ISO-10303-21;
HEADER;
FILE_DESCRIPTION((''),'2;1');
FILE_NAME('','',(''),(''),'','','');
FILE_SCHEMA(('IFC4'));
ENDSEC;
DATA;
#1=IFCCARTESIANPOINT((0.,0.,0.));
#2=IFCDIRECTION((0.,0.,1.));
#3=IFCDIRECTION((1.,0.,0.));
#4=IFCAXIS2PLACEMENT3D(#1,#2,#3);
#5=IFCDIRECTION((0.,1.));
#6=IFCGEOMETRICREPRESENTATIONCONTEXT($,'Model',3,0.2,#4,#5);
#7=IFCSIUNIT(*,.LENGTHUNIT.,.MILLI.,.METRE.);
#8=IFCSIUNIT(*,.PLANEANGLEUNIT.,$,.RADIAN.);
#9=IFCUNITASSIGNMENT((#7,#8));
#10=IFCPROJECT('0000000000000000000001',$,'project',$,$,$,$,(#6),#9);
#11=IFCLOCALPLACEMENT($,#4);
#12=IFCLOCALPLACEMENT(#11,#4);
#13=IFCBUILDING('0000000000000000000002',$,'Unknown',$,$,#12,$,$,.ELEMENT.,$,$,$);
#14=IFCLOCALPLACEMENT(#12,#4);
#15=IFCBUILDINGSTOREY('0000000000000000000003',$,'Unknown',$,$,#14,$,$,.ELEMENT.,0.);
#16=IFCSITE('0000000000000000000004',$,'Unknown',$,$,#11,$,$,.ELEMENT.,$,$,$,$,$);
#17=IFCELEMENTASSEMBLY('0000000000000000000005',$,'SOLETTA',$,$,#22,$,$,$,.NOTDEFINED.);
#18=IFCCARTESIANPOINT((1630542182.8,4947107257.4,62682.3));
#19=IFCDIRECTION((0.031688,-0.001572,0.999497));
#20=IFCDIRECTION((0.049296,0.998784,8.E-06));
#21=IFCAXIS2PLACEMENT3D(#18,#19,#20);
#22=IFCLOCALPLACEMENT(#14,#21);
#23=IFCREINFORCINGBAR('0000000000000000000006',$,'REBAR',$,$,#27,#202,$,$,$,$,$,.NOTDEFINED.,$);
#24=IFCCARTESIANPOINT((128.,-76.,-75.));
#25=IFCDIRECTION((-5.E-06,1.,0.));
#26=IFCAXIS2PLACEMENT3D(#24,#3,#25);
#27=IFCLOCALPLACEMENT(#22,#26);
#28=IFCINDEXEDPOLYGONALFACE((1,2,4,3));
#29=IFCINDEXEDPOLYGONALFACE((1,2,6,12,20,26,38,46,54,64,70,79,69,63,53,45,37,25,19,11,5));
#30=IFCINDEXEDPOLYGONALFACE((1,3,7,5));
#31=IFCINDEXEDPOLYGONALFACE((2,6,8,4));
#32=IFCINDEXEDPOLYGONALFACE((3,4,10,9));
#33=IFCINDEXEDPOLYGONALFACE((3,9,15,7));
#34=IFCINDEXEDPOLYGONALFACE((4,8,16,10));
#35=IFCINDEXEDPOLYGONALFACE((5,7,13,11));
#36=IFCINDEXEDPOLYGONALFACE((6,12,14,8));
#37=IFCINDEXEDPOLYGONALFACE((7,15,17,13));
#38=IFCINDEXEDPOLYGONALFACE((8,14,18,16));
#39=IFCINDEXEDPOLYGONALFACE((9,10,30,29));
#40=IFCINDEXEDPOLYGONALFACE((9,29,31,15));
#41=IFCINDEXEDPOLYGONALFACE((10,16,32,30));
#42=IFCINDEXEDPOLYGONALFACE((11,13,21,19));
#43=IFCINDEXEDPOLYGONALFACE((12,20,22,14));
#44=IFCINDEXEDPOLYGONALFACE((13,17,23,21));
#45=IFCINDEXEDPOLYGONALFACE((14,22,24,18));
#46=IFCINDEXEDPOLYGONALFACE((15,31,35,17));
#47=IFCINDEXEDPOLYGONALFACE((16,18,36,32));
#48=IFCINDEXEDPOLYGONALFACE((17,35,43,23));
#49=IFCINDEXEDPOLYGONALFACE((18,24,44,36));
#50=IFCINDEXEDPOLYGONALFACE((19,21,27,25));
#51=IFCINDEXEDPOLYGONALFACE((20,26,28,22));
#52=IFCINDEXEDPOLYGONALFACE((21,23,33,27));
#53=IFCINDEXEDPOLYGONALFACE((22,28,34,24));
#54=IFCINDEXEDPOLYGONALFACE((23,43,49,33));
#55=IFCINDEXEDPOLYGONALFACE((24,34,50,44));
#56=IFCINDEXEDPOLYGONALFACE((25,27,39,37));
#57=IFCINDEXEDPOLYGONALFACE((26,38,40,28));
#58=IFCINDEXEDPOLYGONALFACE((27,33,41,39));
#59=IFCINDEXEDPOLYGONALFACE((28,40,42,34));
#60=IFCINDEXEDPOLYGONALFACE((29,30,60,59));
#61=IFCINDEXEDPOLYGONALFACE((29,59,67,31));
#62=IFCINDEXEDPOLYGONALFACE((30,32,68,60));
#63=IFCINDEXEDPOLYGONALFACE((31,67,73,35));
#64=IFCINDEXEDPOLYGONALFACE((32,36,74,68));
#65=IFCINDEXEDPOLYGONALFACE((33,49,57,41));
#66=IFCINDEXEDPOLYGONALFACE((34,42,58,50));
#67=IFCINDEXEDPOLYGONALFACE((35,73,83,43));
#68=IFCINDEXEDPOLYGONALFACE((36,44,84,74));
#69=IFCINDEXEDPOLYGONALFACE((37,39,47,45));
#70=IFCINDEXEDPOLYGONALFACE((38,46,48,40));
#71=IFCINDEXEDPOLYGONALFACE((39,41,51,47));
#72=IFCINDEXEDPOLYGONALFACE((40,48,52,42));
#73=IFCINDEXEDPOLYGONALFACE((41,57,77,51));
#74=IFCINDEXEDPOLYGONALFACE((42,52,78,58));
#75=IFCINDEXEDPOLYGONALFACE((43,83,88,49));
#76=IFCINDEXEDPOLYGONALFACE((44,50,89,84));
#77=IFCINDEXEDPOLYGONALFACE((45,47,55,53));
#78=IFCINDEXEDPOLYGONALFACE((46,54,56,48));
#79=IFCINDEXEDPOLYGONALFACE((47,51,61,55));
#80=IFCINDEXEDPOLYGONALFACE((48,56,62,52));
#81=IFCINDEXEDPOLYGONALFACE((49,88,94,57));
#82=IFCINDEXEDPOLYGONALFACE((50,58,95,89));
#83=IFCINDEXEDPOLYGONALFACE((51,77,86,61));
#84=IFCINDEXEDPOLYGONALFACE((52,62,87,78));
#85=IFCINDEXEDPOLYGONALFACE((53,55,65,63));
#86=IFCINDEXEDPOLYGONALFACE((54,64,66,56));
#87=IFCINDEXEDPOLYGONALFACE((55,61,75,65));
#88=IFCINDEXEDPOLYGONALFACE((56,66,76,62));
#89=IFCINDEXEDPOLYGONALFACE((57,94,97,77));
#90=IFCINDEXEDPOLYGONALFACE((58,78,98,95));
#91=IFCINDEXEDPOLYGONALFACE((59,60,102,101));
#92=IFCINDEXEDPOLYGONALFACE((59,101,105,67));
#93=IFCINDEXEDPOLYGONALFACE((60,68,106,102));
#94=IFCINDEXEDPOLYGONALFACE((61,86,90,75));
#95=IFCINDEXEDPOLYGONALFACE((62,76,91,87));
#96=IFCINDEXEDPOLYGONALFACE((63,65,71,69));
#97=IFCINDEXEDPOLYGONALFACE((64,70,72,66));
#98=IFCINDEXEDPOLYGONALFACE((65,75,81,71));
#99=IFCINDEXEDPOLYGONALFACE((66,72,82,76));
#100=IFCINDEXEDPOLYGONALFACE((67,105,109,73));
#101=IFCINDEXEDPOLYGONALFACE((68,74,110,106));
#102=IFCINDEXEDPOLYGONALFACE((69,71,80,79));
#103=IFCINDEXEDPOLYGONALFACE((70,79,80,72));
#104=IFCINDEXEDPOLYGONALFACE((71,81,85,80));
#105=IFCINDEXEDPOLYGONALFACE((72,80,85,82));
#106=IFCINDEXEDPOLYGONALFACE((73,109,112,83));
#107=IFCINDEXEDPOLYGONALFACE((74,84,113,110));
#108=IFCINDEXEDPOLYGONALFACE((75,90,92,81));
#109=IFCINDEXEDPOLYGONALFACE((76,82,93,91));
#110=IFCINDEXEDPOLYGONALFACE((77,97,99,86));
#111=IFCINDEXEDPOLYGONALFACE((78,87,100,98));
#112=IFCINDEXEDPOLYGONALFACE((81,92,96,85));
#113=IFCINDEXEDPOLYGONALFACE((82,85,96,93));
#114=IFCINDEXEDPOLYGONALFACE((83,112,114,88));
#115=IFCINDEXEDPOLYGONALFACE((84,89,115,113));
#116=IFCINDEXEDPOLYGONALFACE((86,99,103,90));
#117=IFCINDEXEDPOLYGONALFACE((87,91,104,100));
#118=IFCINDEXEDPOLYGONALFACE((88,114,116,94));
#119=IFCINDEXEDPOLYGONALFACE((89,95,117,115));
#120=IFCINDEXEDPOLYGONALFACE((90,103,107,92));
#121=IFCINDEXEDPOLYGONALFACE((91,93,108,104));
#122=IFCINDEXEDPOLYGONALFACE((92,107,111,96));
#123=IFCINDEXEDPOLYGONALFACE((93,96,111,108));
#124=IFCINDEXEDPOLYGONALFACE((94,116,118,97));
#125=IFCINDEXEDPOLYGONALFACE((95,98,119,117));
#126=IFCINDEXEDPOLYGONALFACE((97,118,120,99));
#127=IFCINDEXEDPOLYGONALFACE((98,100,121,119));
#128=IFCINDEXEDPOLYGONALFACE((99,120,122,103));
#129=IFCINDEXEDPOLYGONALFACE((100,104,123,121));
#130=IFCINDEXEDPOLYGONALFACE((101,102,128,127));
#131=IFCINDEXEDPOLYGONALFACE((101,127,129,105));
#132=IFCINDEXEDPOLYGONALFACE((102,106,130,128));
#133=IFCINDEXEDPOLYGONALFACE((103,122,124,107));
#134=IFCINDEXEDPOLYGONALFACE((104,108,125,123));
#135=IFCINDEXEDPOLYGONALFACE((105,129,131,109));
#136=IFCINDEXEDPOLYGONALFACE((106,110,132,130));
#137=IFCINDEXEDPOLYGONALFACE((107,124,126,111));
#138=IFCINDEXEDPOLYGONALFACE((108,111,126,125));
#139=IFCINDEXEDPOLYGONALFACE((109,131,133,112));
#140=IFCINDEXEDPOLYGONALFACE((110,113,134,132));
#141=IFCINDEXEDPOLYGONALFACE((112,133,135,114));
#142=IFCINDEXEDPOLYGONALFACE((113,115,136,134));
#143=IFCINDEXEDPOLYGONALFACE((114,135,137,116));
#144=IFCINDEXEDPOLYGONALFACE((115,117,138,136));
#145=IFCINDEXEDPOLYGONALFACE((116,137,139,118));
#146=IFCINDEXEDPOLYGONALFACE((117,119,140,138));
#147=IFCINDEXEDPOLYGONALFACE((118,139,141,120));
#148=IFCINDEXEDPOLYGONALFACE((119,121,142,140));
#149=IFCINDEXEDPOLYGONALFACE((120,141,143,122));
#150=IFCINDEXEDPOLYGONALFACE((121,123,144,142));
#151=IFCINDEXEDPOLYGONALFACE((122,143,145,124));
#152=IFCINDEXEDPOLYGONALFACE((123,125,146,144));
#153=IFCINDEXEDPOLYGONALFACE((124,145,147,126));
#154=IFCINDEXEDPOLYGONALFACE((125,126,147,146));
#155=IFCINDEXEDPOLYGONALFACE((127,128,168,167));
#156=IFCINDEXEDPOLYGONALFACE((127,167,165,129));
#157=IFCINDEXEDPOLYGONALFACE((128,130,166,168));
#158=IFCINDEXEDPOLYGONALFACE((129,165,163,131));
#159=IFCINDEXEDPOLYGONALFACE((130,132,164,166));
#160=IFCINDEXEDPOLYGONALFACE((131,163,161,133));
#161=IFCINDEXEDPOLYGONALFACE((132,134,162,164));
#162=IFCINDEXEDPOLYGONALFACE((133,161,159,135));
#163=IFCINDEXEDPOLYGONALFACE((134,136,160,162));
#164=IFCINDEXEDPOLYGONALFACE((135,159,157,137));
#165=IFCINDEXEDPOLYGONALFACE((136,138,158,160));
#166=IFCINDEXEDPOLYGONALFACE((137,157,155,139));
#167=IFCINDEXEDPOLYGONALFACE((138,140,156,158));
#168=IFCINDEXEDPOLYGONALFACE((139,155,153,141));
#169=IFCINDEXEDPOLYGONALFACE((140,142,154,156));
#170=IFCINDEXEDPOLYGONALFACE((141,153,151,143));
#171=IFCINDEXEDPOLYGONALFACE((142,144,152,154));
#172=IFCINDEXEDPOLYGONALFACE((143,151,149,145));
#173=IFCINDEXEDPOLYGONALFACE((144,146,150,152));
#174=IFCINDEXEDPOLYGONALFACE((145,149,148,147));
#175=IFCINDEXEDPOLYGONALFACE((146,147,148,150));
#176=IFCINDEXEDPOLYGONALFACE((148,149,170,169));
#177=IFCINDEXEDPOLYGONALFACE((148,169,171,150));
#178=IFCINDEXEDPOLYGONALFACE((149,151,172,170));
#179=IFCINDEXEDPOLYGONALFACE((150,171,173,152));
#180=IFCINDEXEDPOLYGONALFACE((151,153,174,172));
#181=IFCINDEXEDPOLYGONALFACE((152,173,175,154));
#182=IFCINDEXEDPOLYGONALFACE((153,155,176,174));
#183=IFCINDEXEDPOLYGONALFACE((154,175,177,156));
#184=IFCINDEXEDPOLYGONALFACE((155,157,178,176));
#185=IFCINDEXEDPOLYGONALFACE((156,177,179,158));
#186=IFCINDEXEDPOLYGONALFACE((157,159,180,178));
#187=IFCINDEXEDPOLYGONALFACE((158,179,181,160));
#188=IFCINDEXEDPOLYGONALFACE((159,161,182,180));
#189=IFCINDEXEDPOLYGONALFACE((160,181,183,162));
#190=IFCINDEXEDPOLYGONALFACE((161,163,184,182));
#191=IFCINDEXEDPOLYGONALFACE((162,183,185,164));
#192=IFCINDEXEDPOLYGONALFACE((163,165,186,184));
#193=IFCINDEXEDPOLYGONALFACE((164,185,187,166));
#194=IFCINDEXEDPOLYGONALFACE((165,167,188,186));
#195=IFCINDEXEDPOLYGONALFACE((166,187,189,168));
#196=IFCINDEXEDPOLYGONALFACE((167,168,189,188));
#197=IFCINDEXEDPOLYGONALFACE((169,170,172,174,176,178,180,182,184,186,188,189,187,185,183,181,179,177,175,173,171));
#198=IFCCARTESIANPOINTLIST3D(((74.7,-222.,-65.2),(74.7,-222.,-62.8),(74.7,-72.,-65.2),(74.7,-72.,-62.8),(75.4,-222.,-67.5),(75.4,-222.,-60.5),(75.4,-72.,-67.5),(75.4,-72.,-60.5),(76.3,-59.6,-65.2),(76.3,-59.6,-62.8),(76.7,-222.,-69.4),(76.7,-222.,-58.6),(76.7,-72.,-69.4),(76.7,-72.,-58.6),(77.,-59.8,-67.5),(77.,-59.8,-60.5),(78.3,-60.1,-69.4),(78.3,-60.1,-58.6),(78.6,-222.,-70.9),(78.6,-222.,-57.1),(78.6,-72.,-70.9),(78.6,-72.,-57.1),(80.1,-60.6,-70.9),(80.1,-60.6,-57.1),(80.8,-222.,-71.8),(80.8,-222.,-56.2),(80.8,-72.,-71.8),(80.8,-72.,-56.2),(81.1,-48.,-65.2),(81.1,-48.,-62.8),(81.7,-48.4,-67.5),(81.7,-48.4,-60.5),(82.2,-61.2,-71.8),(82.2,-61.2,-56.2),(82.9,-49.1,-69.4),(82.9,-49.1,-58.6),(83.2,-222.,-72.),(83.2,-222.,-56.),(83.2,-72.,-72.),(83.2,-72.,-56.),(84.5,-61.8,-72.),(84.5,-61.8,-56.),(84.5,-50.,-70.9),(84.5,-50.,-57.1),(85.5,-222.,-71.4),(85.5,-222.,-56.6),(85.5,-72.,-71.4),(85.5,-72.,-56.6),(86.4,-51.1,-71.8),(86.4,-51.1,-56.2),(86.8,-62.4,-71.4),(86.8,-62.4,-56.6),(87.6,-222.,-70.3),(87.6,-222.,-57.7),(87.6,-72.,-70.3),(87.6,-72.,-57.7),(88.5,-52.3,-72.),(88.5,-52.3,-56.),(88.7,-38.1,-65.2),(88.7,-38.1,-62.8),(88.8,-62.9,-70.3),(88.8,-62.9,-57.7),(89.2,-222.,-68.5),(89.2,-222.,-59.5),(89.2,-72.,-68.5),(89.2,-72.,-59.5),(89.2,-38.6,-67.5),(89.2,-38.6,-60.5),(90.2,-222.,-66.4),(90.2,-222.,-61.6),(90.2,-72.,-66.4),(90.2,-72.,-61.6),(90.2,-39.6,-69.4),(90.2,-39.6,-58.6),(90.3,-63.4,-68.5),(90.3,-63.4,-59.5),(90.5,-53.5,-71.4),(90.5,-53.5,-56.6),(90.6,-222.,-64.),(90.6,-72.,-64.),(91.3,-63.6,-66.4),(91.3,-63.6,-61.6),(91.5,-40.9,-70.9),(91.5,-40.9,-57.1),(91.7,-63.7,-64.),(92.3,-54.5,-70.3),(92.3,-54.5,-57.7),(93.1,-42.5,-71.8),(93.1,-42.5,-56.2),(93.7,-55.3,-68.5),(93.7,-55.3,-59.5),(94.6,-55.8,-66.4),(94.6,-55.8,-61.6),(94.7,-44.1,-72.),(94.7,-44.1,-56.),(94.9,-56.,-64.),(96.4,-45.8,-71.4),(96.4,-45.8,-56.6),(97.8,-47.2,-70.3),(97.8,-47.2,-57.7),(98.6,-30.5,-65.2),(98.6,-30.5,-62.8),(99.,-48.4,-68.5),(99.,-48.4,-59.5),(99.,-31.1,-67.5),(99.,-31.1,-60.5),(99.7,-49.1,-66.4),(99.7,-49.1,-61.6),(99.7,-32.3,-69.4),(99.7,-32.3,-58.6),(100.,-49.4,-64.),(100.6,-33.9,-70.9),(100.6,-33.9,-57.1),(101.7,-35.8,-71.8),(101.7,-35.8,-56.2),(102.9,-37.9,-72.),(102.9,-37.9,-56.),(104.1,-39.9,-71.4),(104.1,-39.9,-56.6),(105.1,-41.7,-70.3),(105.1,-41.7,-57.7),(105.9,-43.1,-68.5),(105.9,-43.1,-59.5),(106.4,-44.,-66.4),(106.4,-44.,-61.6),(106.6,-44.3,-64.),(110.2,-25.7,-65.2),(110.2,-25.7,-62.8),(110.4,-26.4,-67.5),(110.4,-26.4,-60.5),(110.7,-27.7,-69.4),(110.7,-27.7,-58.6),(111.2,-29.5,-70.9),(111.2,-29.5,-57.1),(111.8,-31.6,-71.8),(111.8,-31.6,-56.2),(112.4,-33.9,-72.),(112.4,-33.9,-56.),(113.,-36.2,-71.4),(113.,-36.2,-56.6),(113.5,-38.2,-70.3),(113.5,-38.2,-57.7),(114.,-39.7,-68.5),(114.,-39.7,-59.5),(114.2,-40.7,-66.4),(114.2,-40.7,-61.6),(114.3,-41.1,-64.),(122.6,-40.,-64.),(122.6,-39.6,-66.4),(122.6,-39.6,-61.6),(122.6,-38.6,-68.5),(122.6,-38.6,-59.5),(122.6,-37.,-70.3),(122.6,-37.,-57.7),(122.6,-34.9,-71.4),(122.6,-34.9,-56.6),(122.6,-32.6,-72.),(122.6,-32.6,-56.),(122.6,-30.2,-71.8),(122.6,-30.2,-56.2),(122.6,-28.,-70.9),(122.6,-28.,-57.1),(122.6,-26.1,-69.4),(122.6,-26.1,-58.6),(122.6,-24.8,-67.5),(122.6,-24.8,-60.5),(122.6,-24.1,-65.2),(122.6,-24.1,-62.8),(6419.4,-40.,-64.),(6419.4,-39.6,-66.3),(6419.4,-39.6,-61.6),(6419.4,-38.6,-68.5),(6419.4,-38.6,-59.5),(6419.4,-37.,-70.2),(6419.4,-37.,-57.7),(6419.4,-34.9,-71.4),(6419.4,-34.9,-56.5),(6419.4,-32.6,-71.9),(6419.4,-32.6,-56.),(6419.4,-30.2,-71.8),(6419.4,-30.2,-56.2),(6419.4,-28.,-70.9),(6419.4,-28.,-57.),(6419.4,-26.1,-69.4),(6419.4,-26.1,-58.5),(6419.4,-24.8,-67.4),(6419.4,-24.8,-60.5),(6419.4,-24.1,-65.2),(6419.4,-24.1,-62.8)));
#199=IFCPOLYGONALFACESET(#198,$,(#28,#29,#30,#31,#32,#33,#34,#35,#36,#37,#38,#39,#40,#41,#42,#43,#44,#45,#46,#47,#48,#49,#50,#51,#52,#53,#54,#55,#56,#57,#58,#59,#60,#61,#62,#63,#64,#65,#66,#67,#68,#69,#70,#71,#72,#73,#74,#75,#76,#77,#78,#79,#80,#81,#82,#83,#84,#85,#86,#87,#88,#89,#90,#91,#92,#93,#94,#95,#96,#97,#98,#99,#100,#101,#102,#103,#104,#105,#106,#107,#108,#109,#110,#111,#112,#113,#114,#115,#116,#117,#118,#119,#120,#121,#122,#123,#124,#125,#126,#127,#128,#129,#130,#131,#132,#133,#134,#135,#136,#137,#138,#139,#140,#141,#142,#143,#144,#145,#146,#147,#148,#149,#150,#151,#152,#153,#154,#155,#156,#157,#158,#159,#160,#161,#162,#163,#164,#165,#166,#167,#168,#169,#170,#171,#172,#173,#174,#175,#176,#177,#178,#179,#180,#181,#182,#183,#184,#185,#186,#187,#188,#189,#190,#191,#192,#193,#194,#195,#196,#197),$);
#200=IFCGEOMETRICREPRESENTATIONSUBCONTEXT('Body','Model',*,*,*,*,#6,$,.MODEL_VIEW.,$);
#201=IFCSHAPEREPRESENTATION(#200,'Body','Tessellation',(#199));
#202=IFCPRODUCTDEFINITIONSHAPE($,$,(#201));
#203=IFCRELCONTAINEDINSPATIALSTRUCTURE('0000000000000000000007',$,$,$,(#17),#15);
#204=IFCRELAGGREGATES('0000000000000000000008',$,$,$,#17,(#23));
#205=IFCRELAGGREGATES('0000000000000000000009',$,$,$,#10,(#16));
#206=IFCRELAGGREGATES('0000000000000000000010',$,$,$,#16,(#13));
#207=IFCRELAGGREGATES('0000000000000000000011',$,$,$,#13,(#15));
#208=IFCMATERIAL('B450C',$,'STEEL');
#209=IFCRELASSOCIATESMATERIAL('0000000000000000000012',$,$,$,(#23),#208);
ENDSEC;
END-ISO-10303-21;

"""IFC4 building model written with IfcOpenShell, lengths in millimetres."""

from ifc_helpers import new_model, entity, si_unit, direction, frame, origin_with_axes, place, context, subcontext, project, spatial, material, element, aggregate, save


model = new_model("IFC4")

# Units and contexts
model_context = context("Model", 3, precision=0.2, world=origin_with_axes(), true_north=direction((0.0, 1.0)))
body_context = subcontext(model_context, "Body", "Model", "MODEL_VIEW")
ifc_project = project(units=[si_unit("LENGTHUNIT", "METRE", prefix="MILLI"), si_unit("PLANEANGLEUNIT", "RADIAN")], contexts=[model_context])

# Site, building, storey
site_placement = place(None, origin_with_axes())
site = spatial("IfcSite", under=ifc_project, at=site_placement, Name="Unknown", CompositionType="ELEMENT")
building_placement = place(site_placement, origin_with_axes())
building = spatial("IfcBuilding", under=site, at=building_placement, Name="Unknown", CompositionType="ELEMENT")
storey_placement = place(building_placement, origin_with_axes())
storey = spatial("IfcBuildingStorey", under=building, at=storey_placement, Name="Unknown", CompositionType="ELEMENT", Elevation=0.0)

# Element assembly, reinforcing bar
ifc_material = material(Name="B450C", Category="STEEL")
assembly_1_placement = place(storey_placement, frame((1630542182.8, 4947107257.4, 62682.3), z_axis=(0.031688, -0.001572, 0.999497), x_axis=(0.049296, 0.998784, 0.000008)))
assembly_1 = element("IfcElementAssembly", 1, at=assembly_1_placement, inside=storey, Name="SOLETTA", PredefinedType="NOTDEFINED")
reinforcing_bar_1_placement = place(assembly_1_placement, frame((128.0, -76.0, -75.0), z_axis=(1.0, 0.0, 0.0), x_axis=(-0.000005, 1.0, 0.0)))
reinforcing_bar_1 = element("IfcReinforcingBar", 2, at=reinforcing_bar_1_placement, material=ifc_material, Name="REBAR", PredefinedType="NOTDEFINED", context=body_context, shape_type="AdvancedSweptSolid", body=[
    entity("IfcSweptDiskSolid", entity("IfcIndexedPolyCurve", entity("IfcCartesianPointList3D", [[82.6, -222.0, -64.0], [82.6, -72.0, -64.0], [94.3, -43.7, -64.0], [122.6, -32.0, -64.0], [6419.4, -32.0, -64.0]]), [entity("IfcLineIndex", [1, 2]), entity("IfcArcIndex", [2, 3, 4]), entity("IfcLineIndex", [4, 5])]), 8.0),
])
aggregate(assembly_1, [reinforcing_bar_1])

save(model, "model.ifc")
